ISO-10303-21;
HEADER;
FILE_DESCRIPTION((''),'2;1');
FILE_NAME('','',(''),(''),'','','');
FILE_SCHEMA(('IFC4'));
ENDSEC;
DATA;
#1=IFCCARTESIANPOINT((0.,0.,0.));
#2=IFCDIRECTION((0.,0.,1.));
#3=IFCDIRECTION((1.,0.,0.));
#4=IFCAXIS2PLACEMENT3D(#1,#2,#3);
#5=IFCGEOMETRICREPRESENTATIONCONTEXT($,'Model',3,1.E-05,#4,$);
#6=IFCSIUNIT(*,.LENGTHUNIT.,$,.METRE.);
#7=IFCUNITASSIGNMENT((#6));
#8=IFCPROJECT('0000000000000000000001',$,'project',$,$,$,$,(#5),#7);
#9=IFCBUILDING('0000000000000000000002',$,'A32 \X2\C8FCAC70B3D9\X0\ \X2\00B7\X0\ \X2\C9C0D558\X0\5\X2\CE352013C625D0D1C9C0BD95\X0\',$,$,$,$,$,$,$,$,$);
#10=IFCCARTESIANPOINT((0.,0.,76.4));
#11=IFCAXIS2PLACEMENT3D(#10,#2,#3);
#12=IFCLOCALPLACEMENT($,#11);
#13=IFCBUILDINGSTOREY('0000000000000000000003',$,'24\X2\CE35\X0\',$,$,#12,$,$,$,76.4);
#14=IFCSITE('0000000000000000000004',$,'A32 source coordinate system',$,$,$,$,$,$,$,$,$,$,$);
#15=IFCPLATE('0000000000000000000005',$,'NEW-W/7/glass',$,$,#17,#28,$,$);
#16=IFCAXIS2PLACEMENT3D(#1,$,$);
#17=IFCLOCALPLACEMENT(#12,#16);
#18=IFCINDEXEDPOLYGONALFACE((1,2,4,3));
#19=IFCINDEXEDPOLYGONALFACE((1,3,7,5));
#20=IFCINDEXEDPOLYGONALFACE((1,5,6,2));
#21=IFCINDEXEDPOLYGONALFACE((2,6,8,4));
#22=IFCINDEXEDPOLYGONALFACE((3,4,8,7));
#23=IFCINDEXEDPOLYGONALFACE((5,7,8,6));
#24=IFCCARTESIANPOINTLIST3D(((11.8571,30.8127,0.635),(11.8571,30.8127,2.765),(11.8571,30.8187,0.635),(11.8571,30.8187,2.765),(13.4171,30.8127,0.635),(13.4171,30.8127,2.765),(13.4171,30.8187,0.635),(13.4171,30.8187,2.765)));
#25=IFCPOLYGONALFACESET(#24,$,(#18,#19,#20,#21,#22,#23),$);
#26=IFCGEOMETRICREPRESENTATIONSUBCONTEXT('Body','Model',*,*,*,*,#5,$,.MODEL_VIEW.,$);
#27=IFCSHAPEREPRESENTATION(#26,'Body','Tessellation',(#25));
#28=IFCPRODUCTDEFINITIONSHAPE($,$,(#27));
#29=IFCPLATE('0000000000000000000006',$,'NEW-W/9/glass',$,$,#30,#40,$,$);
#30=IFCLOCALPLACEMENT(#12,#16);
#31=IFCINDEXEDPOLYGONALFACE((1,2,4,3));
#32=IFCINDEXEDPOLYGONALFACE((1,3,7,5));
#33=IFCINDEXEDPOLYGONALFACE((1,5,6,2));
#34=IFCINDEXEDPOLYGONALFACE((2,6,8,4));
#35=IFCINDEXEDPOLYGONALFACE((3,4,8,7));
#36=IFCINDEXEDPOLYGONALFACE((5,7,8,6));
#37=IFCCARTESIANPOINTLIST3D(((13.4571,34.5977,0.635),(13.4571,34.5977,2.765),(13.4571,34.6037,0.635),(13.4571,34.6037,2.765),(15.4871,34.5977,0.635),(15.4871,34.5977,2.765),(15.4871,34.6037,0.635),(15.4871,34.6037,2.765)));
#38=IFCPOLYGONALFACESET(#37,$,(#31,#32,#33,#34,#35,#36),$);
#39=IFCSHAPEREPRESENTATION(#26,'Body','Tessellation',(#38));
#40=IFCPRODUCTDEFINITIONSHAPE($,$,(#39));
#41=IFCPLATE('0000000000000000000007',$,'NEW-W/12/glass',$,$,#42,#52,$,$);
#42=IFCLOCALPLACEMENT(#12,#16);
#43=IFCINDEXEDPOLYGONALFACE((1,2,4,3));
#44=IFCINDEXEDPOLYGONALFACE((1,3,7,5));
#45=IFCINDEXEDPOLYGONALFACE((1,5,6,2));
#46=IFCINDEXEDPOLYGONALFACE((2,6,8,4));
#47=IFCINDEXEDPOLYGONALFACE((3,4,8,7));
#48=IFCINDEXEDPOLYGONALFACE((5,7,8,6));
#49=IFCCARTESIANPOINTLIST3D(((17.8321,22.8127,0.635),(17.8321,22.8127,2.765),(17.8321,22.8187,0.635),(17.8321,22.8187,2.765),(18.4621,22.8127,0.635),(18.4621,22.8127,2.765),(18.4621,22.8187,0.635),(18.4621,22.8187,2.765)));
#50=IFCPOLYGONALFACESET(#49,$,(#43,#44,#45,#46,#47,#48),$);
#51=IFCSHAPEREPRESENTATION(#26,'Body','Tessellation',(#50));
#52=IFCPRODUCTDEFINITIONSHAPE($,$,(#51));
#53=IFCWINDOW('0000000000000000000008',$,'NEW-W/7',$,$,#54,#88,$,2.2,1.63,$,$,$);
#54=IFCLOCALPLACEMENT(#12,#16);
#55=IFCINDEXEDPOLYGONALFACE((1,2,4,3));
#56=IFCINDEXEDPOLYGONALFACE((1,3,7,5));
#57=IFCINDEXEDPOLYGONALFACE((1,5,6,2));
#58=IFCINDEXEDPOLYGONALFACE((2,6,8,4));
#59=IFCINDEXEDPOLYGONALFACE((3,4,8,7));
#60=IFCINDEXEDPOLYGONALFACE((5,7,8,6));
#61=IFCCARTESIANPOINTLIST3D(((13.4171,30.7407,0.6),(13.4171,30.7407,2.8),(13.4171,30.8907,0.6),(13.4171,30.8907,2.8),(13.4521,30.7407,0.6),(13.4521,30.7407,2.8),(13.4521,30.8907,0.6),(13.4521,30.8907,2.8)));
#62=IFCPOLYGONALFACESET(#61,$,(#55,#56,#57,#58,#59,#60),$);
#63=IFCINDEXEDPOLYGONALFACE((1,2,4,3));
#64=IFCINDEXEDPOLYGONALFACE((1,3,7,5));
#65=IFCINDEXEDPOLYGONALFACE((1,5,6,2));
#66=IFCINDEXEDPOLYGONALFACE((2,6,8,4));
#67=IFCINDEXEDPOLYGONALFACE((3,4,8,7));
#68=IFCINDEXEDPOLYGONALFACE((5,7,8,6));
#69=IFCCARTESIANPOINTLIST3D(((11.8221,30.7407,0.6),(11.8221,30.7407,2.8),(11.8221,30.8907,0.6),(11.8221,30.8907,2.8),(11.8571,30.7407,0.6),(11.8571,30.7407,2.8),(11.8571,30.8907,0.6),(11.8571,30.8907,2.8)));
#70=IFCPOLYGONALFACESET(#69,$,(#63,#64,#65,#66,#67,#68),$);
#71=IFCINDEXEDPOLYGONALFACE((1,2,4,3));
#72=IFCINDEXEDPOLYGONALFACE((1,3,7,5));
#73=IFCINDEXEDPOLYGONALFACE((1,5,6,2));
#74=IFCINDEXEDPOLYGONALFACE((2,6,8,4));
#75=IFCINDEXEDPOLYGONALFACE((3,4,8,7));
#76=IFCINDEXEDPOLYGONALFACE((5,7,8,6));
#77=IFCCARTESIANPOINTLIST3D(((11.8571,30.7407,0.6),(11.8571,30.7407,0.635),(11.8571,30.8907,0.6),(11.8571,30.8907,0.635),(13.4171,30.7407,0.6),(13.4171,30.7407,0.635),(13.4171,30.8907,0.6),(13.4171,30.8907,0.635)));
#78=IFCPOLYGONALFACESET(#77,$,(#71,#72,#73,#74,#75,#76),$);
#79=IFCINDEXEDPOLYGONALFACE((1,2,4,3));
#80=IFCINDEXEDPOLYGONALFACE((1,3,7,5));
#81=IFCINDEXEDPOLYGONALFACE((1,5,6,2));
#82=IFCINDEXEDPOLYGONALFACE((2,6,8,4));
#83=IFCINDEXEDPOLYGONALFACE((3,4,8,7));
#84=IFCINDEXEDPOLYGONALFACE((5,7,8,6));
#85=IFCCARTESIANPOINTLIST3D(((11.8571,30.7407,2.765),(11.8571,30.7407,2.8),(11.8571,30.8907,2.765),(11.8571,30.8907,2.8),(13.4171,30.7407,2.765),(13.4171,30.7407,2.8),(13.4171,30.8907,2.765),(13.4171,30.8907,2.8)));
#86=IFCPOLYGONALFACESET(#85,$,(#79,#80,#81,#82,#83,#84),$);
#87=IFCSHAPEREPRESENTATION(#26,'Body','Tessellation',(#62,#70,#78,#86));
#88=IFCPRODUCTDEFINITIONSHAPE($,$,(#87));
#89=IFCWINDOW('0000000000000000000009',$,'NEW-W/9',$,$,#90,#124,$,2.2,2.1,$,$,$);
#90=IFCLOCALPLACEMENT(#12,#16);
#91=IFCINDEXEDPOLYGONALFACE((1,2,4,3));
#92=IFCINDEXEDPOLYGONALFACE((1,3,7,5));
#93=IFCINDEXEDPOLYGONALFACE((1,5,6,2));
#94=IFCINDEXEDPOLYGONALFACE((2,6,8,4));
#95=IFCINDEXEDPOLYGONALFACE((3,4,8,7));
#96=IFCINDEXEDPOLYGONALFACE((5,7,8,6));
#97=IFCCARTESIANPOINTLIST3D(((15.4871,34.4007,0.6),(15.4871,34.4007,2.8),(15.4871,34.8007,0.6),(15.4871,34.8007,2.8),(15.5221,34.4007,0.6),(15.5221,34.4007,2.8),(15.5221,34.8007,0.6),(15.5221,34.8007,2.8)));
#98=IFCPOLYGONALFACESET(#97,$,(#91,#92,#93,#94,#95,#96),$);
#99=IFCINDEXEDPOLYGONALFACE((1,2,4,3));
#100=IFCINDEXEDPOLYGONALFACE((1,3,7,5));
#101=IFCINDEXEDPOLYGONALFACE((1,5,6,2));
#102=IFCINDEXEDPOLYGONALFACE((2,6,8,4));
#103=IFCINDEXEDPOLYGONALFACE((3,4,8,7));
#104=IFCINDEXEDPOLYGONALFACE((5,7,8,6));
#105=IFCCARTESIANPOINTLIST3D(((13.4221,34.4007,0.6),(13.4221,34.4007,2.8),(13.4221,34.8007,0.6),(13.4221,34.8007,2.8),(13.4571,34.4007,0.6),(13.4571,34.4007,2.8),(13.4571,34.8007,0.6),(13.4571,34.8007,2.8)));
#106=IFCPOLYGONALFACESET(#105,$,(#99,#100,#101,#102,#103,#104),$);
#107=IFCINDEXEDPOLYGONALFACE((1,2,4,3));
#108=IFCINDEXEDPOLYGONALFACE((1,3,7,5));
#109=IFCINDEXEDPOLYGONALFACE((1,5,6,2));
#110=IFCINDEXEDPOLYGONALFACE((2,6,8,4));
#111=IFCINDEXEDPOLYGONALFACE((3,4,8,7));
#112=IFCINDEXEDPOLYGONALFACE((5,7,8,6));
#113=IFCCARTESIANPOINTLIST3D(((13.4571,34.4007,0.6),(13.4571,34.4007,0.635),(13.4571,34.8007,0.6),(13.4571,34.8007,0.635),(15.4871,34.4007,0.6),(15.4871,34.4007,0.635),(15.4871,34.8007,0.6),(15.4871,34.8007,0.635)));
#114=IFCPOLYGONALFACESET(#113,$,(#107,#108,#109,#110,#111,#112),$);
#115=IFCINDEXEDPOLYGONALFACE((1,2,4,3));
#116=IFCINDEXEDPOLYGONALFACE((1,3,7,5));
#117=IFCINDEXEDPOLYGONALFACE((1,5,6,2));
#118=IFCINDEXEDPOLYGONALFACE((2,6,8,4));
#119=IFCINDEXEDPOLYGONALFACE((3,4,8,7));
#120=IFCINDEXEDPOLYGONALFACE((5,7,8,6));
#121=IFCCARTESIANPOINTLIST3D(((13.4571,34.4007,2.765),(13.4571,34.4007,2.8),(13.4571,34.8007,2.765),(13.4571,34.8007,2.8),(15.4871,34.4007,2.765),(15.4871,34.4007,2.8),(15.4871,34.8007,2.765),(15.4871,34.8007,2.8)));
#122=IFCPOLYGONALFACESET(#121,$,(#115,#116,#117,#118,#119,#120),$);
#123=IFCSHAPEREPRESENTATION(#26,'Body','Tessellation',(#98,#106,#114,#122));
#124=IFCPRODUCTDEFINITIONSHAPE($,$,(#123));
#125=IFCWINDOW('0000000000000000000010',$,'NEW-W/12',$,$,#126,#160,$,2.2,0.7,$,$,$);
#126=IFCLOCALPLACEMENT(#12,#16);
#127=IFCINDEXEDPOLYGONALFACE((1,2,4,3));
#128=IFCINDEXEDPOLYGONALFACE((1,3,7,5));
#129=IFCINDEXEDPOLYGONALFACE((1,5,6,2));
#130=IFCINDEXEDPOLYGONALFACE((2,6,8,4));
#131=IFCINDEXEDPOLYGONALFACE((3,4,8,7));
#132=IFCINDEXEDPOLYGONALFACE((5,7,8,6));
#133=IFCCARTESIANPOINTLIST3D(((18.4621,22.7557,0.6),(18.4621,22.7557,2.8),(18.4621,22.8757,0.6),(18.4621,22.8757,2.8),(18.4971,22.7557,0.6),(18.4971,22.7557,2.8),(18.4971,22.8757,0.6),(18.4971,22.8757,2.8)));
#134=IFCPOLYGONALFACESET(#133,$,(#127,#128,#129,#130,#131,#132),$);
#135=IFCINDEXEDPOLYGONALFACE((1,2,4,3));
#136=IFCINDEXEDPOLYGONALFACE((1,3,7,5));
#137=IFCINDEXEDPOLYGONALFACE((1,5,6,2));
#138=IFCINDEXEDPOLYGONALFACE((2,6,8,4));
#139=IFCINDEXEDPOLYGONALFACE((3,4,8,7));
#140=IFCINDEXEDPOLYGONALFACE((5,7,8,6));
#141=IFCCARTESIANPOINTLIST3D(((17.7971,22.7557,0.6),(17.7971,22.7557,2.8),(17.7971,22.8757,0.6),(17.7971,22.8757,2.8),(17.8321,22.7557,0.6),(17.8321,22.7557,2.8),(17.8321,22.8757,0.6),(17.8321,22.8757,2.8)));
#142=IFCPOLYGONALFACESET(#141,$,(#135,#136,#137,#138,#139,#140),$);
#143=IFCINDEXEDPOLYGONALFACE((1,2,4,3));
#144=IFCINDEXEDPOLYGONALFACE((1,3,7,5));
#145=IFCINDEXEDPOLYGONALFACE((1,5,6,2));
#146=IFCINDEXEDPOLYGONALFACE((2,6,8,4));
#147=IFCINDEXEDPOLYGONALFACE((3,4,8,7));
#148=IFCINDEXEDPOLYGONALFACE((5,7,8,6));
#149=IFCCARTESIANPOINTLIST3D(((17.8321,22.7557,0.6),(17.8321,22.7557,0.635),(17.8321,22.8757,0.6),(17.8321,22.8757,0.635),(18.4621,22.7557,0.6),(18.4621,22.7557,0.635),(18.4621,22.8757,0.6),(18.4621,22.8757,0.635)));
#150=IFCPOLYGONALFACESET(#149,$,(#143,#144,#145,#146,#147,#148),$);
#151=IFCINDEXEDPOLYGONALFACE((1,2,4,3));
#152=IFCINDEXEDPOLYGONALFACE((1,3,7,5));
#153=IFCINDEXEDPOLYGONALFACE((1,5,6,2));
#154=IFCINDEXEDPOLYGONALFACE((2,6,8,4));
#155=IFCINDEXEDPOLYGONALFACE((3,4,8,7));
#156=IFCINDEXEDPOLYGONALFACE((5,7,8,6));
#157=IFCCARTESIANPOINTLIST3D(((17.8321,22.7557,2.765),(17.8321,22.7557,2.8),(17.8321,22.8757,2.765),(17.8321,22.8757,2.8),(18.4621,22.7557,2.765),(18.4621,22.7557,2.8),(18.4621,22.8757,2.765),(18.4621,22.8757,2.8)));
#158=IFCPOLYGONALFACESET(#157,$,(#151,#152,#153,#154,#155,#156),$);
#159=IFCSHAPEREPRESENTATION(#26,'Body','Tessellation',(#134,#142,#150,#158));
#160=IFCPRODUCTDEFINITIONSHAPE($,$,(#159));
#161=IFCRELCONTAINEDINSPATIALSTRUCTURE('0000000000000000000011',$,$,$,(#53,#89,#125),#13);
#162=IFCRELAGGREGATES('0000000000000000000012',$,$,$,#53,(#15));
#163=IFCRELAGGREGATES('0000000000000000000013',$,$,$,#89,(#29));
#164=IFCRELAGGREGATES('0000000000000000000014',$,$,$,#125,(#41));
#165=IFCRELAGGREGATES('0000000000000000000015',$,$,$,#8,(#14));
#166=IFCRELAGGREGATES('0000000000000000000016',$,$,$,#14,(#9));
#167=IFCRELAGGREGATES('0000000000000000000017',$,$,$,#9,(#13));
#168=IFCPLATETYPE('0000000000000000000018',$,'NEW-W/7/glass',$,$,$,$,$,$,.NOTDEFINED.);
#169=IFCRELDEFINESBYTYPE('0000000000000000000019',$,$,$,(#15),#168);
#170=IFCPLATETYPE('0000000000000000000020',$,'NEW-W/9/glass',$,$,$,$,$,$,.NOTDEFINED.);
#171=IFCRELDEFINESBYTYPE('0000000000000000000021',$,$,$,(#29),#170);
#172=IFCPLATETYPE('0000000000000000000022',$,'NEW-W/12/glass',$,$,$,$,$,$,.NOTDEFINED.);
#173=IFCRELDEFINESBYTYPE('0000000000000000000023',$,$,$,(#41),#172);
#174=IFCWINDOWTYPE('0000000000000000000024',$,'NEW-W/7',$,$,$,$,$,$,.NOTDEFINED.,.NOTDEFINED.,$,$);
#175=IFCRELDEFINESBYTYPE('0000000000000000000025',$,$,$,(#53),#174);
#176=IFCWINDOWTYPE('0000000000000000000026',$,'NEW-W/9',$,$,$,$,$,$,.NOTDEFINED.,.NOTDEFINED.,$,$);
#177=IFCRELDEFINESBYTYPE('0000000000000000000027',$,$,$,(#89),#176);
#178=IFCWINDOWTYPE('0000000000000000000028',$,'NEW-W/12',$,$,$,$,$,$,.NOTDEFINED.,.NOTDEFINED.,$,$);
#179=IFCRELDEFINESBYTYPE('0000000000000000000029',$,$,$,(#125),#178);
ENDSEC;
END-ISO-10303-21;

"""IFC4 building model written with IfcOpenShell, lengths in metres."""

from ifc_helpers import new_model, si_unit, frame, origin, origin_with_axes, place, context, subcontext, project, spatial, polyline, outline, extrude, source, transform, mapped, type_object, type_shapes, element, aggregate, save


model = new_model("IFC4")

# Units and contexts
model_context = context("Model", 3, precision=1e-05, world=origin_with_axes())
body_context = subcontext(model_context, "Body", "Model", "MODEL_VIEW")
ifc_project = project(units=[si_unit("LENGTHUNIT", "METRE")], contexts=[model_context])

# Plates
plate_type_1 = type_object("IfcPlateType", Name="NEW-W/7/glass", PredefinedType="NOTDEFINED")
shared_shape_1 = source(origin(), body_context, "Body", "SweptSolid", [
    extrude(outline(polyline([(13.4171, 30.8127), (11.8571, 30.8127), (11.8571, 30.8187), (13.4171, 30.8187), (13.4171, 30.8127)])), frame((0.0, 0.0, 0.635)), (0.0, 0.0, 1.0), 2.13),
])
type_shapes(plate_type_1, [shared_shape_1])
storey_placement = place(None, frame((0.0, 0.0, 76.4), z_axis=(0.0, 0.0, 1.0), x_axis=(1.0, 0.0, 0.0)))
window_1_placement = place(storey_placement, origin_with_axes())
plate_1_placement = place(window_1_placement, origin_with_axes())
plate_1 = element("IfcPlate", 1, at=plate_1_placement, type_object=plate_type_1, Name="NEW-W/7/glass", context=body_context, shape_type="MappedRepresentation", body=[
    mapped(shared_shape_1, transform((0.0, 0.0, 0.0), scale=1.0)),
])
plate_type_2 = type_object("IfcPlateType", Name="NEW-W/9/glass", PredefinedType="NOTDEFINED")
shared_shape_2 = source(origin(), body_context, "Body", "SweptSolid", [
    extrude(outline(polyline([(15.4871, 34.5977), (13.4571, 34.5977), (13.4571, 34.6037), (15.4871, 34.6037), (15.4871, 34.5977)])), frame((0.0, 0.0, 0.635)), (0.0, 0.0, 1.0), 2.13),
])
type_shapes(plate_type_2, [shared_shape_2])
window_2_placement = place(storey_placement, origin_with_axes())
plate_2_placement = place(window_2_placement, origin_with_axes())
plate_2 = element("IfcPlate", 2, at=plate_2_placement, type_object=plate_type_2, Name="NEW-W/9/glass", context=body_context, shape_type="MappedRepresentation", body=[
    mapped(shared_shape_2, transform((0.0, 0.0, 0.0), scale=1.0)),
])
plate_type_3 = type_object("IfcPlateType", Name="NEW-W/12/glass", PredefinedType="NOTDEFINED")
shared_shape_3 = source(origin(), body_context, "Body", "SweptSolid", [
    extrude(outline(polyline([(18.4621, 22.8127), (17.8321, 22.8127), (17.8321, 22.8187), (18.4621, 22.8187), (18.4621, 22.8127)])), frame((0.0, 0.0, 0.635)), (0.0, 0.0, 1.0), 2.13),
])
type_shapes(plate_type_3, [shared_shape_3])
window_3_placement = place(storey_placement, origin_with_axes())
plate_3_placement = place(window_3_placement, origin_with_axes())
plate_3 = element("IfcPlate", 3, at=plate_3_placement, type_object=plate_type_3, Name="NEW-W/12/glass", context=body_context, shape_type="MappedRepresentation", body=[
    mapped(shared_shape_3, transform((0.0, 0.0, 0.0), scale=1.0)),
])

# Site, building, storey
site = spatial("IfcSite", under=ifc_project, Name="A32 source coordinate system")
building = spatial("IfcBuilding", under=site, Name="A32 주거동 · 지하5층–옥탑지붕")
storey = spatial("IfcBuildingStorey", under=building, at=storey_placement, Name="24층", Elevation=76.4)

# Windows
window_type_1 = type_object("IfcWindowType", Name="NEW-W/7", PartitioningType="NOTDEFINED", PredefinedType="NOTDEFINED")
shared_shape_4 = source(origin(), body_context, "Body", "SweptSolid", [
    extrude(outline(polyline([(13.4171, 30.7407), (13.4171, 30.8907), (13.4521, 30.8907), (13.4521, 30.7407), (13.4171, 30.7407)])), frame((0.0, 0.0, 0.6)), (0.0, 0.0, 1.0), 2.2),
    extrude(outline(polyline([(11.8221, 30.7407), (11.8221, 30.8907), (11.8571, 30.8907), (11.8571, 30.7407), (11.8221, 30.7407)])), frame((0.0, 0.0, 0.6)), (0.0, 0.0, 1.0), 2.2),
    extrude(outline(polyline([(13.4171, 30.7407), (13.4171, 30.8907), (11.8571, 30.8907), (11.8571, 30.7407), (13.4171, 30.7407)])), frame((0.0, 0.0, 0.6)), (0.0, 0.0, 1.0), 0.035),
    extrude(outline(polyline([(13.4171, 30.7407), (13.4171, 30.8907), (11.8571, 30.8907), (11.8571, 30.7407), (13.4171, 30.7407)])), frame((0.0, 0.0, 2.765)), (0.0, 0.0, 1.0), 0.035),
])
type_shapes(window_type_1, [shared_shape_4])
window_1 = element("IfcWindow", 4, at=window_1_placement, inside=storey, type_object=window_type_1, Name="NEW-W/7", OverallHeight=2.2, OverallWidth=1.63, context=body_context, shape_type="MappedRepresentation", body=[
    mapped(shared_shape_4, transform((0.0, 0.0, 0.0), scale=1.0)),
])
aggregate(window_1, [plate_1])
window_type_2 = type_object("IfcWindowType", Name="NEW-W/9", PartitioningType="NOTDEFINED", PredefinedType="NOTDEFINED")
shared_shape_5 = source(origin(), body_context, "Body", "SweptSolid", [
    extrude(outline(polyline([(15.4871, 34.4007), (15.4871, 34.8007), (15.5221, 34.8007), (15.5221, 34.4007), (15.4871, 34.4007)])), frame((0.0, 0.0, 0.6)), (0.0, 0.0, 1.0), 2.2),
    extrude(outline(polyline([(13.4221, 34.4007), (13.4221, 34.8007), (13.4571, 34.8007), (13.4571, 34.4007), (13.4221, 34.4007)])), frame((0.0, 0.0, 0.6)), (0.0, 0.0, 1.0), 2.2),
    extrude(outline(polyline([(15.4871, 34.4007), (15.4871, 34.8007), (13.4571, 34.8007), (13.4571, 34.4007), (15.4871, 34.4007)])), frame((0.0, 0.0, 0.6)), (0.0, 0.0, 1.0), 0.035),
    extrude(outline(polyline([(15.4871, 34.4007), (15.4871, 34.8007), (13.4571, 34.8007), (13.4571, 34.4007), (15.4871, 34.4007)])), frame((0.0, 0.0, 2.765)), (0.0, 0.0, 1.0), 0.035),
])
type_shapes(window_type_2, [shared_shape_5])
window_2 = element("IfcWindow", 5, at=window_2_placement, inside=storey, type_object=window_type_2, Name="NEW-W/9", OverallHeight=2.2, OverallWidth=2.1, context=body_context, shape_type="MappedRepresentation", body=[
    mapped(shared_shape_5, transform((0.0, 0.0, 0.0), scale=1.0)),
])
aggregate(window_2, [plate_2])
window_type_3 = type_object("IfcWindowType", Name="NEW-W/12", PartitioningType="NOTDEFINED", PredefinedType="NOTDEFINED")
shared_shape_6 = source(origin(), body_context, "Body", "SweptSolid", [
    extrude(outline(polyline([(18.4621, 22.7557), (18.4621, 22.8757), (18.4971, 22.8757), (18.4971, 22.7557), (18.4621, 22.7557)])), frame((0.0, 0.0, 0.6)), (0.0, 0.0, 1.0), 2.2),
    extrude(outline(polyline([(17.7971, 22.7557), (17.7971, 22.8757), (17.8321, 22.8757), (17.8321, 22.7557), (17.7971, 22.7557)])), frame((0.0, 0.0, 0.6)), (0.0, 0.0, 1.0), 2.2),
    extrude(outline(polyline([(18.4621, 22.7557), (18.4621, 22.8757), (17.8321, 22.8757), (17.8321, 22.7557), (18.4621, 22.7557)])), frame((0.0, 0.0, 0.6)), (0.0, 0.0, 1.0), 0.035),
    extrude(outline(polyline([(18.4621, 22.7557), (18.4621, 22.8757), (17.8321, 22.8757), (17.8321, 22.7557), (18.4621, 22.7557)])), frame((0.0, 0.0, 2.765)), (0.0, 0.0, 1.0), 0.035),
])
type_shapes(window_type_3, [shared_shape_6])
window_3 = element("IfcWindow", 6, at=window_3_placement, inside=storey, type_object=window_type_3, Name="NEW-W/12", OverallHeight=2.2, OverallWidth=0.7, context=body_context, shape_type="MappedRepresentation", body=[
    mapped(shared_shape_6, transform((0.0, 0.0, 0.0), scale=1.0)),
])
aggregate(window_3, [plate_3])

save(model, "model.ifc")
